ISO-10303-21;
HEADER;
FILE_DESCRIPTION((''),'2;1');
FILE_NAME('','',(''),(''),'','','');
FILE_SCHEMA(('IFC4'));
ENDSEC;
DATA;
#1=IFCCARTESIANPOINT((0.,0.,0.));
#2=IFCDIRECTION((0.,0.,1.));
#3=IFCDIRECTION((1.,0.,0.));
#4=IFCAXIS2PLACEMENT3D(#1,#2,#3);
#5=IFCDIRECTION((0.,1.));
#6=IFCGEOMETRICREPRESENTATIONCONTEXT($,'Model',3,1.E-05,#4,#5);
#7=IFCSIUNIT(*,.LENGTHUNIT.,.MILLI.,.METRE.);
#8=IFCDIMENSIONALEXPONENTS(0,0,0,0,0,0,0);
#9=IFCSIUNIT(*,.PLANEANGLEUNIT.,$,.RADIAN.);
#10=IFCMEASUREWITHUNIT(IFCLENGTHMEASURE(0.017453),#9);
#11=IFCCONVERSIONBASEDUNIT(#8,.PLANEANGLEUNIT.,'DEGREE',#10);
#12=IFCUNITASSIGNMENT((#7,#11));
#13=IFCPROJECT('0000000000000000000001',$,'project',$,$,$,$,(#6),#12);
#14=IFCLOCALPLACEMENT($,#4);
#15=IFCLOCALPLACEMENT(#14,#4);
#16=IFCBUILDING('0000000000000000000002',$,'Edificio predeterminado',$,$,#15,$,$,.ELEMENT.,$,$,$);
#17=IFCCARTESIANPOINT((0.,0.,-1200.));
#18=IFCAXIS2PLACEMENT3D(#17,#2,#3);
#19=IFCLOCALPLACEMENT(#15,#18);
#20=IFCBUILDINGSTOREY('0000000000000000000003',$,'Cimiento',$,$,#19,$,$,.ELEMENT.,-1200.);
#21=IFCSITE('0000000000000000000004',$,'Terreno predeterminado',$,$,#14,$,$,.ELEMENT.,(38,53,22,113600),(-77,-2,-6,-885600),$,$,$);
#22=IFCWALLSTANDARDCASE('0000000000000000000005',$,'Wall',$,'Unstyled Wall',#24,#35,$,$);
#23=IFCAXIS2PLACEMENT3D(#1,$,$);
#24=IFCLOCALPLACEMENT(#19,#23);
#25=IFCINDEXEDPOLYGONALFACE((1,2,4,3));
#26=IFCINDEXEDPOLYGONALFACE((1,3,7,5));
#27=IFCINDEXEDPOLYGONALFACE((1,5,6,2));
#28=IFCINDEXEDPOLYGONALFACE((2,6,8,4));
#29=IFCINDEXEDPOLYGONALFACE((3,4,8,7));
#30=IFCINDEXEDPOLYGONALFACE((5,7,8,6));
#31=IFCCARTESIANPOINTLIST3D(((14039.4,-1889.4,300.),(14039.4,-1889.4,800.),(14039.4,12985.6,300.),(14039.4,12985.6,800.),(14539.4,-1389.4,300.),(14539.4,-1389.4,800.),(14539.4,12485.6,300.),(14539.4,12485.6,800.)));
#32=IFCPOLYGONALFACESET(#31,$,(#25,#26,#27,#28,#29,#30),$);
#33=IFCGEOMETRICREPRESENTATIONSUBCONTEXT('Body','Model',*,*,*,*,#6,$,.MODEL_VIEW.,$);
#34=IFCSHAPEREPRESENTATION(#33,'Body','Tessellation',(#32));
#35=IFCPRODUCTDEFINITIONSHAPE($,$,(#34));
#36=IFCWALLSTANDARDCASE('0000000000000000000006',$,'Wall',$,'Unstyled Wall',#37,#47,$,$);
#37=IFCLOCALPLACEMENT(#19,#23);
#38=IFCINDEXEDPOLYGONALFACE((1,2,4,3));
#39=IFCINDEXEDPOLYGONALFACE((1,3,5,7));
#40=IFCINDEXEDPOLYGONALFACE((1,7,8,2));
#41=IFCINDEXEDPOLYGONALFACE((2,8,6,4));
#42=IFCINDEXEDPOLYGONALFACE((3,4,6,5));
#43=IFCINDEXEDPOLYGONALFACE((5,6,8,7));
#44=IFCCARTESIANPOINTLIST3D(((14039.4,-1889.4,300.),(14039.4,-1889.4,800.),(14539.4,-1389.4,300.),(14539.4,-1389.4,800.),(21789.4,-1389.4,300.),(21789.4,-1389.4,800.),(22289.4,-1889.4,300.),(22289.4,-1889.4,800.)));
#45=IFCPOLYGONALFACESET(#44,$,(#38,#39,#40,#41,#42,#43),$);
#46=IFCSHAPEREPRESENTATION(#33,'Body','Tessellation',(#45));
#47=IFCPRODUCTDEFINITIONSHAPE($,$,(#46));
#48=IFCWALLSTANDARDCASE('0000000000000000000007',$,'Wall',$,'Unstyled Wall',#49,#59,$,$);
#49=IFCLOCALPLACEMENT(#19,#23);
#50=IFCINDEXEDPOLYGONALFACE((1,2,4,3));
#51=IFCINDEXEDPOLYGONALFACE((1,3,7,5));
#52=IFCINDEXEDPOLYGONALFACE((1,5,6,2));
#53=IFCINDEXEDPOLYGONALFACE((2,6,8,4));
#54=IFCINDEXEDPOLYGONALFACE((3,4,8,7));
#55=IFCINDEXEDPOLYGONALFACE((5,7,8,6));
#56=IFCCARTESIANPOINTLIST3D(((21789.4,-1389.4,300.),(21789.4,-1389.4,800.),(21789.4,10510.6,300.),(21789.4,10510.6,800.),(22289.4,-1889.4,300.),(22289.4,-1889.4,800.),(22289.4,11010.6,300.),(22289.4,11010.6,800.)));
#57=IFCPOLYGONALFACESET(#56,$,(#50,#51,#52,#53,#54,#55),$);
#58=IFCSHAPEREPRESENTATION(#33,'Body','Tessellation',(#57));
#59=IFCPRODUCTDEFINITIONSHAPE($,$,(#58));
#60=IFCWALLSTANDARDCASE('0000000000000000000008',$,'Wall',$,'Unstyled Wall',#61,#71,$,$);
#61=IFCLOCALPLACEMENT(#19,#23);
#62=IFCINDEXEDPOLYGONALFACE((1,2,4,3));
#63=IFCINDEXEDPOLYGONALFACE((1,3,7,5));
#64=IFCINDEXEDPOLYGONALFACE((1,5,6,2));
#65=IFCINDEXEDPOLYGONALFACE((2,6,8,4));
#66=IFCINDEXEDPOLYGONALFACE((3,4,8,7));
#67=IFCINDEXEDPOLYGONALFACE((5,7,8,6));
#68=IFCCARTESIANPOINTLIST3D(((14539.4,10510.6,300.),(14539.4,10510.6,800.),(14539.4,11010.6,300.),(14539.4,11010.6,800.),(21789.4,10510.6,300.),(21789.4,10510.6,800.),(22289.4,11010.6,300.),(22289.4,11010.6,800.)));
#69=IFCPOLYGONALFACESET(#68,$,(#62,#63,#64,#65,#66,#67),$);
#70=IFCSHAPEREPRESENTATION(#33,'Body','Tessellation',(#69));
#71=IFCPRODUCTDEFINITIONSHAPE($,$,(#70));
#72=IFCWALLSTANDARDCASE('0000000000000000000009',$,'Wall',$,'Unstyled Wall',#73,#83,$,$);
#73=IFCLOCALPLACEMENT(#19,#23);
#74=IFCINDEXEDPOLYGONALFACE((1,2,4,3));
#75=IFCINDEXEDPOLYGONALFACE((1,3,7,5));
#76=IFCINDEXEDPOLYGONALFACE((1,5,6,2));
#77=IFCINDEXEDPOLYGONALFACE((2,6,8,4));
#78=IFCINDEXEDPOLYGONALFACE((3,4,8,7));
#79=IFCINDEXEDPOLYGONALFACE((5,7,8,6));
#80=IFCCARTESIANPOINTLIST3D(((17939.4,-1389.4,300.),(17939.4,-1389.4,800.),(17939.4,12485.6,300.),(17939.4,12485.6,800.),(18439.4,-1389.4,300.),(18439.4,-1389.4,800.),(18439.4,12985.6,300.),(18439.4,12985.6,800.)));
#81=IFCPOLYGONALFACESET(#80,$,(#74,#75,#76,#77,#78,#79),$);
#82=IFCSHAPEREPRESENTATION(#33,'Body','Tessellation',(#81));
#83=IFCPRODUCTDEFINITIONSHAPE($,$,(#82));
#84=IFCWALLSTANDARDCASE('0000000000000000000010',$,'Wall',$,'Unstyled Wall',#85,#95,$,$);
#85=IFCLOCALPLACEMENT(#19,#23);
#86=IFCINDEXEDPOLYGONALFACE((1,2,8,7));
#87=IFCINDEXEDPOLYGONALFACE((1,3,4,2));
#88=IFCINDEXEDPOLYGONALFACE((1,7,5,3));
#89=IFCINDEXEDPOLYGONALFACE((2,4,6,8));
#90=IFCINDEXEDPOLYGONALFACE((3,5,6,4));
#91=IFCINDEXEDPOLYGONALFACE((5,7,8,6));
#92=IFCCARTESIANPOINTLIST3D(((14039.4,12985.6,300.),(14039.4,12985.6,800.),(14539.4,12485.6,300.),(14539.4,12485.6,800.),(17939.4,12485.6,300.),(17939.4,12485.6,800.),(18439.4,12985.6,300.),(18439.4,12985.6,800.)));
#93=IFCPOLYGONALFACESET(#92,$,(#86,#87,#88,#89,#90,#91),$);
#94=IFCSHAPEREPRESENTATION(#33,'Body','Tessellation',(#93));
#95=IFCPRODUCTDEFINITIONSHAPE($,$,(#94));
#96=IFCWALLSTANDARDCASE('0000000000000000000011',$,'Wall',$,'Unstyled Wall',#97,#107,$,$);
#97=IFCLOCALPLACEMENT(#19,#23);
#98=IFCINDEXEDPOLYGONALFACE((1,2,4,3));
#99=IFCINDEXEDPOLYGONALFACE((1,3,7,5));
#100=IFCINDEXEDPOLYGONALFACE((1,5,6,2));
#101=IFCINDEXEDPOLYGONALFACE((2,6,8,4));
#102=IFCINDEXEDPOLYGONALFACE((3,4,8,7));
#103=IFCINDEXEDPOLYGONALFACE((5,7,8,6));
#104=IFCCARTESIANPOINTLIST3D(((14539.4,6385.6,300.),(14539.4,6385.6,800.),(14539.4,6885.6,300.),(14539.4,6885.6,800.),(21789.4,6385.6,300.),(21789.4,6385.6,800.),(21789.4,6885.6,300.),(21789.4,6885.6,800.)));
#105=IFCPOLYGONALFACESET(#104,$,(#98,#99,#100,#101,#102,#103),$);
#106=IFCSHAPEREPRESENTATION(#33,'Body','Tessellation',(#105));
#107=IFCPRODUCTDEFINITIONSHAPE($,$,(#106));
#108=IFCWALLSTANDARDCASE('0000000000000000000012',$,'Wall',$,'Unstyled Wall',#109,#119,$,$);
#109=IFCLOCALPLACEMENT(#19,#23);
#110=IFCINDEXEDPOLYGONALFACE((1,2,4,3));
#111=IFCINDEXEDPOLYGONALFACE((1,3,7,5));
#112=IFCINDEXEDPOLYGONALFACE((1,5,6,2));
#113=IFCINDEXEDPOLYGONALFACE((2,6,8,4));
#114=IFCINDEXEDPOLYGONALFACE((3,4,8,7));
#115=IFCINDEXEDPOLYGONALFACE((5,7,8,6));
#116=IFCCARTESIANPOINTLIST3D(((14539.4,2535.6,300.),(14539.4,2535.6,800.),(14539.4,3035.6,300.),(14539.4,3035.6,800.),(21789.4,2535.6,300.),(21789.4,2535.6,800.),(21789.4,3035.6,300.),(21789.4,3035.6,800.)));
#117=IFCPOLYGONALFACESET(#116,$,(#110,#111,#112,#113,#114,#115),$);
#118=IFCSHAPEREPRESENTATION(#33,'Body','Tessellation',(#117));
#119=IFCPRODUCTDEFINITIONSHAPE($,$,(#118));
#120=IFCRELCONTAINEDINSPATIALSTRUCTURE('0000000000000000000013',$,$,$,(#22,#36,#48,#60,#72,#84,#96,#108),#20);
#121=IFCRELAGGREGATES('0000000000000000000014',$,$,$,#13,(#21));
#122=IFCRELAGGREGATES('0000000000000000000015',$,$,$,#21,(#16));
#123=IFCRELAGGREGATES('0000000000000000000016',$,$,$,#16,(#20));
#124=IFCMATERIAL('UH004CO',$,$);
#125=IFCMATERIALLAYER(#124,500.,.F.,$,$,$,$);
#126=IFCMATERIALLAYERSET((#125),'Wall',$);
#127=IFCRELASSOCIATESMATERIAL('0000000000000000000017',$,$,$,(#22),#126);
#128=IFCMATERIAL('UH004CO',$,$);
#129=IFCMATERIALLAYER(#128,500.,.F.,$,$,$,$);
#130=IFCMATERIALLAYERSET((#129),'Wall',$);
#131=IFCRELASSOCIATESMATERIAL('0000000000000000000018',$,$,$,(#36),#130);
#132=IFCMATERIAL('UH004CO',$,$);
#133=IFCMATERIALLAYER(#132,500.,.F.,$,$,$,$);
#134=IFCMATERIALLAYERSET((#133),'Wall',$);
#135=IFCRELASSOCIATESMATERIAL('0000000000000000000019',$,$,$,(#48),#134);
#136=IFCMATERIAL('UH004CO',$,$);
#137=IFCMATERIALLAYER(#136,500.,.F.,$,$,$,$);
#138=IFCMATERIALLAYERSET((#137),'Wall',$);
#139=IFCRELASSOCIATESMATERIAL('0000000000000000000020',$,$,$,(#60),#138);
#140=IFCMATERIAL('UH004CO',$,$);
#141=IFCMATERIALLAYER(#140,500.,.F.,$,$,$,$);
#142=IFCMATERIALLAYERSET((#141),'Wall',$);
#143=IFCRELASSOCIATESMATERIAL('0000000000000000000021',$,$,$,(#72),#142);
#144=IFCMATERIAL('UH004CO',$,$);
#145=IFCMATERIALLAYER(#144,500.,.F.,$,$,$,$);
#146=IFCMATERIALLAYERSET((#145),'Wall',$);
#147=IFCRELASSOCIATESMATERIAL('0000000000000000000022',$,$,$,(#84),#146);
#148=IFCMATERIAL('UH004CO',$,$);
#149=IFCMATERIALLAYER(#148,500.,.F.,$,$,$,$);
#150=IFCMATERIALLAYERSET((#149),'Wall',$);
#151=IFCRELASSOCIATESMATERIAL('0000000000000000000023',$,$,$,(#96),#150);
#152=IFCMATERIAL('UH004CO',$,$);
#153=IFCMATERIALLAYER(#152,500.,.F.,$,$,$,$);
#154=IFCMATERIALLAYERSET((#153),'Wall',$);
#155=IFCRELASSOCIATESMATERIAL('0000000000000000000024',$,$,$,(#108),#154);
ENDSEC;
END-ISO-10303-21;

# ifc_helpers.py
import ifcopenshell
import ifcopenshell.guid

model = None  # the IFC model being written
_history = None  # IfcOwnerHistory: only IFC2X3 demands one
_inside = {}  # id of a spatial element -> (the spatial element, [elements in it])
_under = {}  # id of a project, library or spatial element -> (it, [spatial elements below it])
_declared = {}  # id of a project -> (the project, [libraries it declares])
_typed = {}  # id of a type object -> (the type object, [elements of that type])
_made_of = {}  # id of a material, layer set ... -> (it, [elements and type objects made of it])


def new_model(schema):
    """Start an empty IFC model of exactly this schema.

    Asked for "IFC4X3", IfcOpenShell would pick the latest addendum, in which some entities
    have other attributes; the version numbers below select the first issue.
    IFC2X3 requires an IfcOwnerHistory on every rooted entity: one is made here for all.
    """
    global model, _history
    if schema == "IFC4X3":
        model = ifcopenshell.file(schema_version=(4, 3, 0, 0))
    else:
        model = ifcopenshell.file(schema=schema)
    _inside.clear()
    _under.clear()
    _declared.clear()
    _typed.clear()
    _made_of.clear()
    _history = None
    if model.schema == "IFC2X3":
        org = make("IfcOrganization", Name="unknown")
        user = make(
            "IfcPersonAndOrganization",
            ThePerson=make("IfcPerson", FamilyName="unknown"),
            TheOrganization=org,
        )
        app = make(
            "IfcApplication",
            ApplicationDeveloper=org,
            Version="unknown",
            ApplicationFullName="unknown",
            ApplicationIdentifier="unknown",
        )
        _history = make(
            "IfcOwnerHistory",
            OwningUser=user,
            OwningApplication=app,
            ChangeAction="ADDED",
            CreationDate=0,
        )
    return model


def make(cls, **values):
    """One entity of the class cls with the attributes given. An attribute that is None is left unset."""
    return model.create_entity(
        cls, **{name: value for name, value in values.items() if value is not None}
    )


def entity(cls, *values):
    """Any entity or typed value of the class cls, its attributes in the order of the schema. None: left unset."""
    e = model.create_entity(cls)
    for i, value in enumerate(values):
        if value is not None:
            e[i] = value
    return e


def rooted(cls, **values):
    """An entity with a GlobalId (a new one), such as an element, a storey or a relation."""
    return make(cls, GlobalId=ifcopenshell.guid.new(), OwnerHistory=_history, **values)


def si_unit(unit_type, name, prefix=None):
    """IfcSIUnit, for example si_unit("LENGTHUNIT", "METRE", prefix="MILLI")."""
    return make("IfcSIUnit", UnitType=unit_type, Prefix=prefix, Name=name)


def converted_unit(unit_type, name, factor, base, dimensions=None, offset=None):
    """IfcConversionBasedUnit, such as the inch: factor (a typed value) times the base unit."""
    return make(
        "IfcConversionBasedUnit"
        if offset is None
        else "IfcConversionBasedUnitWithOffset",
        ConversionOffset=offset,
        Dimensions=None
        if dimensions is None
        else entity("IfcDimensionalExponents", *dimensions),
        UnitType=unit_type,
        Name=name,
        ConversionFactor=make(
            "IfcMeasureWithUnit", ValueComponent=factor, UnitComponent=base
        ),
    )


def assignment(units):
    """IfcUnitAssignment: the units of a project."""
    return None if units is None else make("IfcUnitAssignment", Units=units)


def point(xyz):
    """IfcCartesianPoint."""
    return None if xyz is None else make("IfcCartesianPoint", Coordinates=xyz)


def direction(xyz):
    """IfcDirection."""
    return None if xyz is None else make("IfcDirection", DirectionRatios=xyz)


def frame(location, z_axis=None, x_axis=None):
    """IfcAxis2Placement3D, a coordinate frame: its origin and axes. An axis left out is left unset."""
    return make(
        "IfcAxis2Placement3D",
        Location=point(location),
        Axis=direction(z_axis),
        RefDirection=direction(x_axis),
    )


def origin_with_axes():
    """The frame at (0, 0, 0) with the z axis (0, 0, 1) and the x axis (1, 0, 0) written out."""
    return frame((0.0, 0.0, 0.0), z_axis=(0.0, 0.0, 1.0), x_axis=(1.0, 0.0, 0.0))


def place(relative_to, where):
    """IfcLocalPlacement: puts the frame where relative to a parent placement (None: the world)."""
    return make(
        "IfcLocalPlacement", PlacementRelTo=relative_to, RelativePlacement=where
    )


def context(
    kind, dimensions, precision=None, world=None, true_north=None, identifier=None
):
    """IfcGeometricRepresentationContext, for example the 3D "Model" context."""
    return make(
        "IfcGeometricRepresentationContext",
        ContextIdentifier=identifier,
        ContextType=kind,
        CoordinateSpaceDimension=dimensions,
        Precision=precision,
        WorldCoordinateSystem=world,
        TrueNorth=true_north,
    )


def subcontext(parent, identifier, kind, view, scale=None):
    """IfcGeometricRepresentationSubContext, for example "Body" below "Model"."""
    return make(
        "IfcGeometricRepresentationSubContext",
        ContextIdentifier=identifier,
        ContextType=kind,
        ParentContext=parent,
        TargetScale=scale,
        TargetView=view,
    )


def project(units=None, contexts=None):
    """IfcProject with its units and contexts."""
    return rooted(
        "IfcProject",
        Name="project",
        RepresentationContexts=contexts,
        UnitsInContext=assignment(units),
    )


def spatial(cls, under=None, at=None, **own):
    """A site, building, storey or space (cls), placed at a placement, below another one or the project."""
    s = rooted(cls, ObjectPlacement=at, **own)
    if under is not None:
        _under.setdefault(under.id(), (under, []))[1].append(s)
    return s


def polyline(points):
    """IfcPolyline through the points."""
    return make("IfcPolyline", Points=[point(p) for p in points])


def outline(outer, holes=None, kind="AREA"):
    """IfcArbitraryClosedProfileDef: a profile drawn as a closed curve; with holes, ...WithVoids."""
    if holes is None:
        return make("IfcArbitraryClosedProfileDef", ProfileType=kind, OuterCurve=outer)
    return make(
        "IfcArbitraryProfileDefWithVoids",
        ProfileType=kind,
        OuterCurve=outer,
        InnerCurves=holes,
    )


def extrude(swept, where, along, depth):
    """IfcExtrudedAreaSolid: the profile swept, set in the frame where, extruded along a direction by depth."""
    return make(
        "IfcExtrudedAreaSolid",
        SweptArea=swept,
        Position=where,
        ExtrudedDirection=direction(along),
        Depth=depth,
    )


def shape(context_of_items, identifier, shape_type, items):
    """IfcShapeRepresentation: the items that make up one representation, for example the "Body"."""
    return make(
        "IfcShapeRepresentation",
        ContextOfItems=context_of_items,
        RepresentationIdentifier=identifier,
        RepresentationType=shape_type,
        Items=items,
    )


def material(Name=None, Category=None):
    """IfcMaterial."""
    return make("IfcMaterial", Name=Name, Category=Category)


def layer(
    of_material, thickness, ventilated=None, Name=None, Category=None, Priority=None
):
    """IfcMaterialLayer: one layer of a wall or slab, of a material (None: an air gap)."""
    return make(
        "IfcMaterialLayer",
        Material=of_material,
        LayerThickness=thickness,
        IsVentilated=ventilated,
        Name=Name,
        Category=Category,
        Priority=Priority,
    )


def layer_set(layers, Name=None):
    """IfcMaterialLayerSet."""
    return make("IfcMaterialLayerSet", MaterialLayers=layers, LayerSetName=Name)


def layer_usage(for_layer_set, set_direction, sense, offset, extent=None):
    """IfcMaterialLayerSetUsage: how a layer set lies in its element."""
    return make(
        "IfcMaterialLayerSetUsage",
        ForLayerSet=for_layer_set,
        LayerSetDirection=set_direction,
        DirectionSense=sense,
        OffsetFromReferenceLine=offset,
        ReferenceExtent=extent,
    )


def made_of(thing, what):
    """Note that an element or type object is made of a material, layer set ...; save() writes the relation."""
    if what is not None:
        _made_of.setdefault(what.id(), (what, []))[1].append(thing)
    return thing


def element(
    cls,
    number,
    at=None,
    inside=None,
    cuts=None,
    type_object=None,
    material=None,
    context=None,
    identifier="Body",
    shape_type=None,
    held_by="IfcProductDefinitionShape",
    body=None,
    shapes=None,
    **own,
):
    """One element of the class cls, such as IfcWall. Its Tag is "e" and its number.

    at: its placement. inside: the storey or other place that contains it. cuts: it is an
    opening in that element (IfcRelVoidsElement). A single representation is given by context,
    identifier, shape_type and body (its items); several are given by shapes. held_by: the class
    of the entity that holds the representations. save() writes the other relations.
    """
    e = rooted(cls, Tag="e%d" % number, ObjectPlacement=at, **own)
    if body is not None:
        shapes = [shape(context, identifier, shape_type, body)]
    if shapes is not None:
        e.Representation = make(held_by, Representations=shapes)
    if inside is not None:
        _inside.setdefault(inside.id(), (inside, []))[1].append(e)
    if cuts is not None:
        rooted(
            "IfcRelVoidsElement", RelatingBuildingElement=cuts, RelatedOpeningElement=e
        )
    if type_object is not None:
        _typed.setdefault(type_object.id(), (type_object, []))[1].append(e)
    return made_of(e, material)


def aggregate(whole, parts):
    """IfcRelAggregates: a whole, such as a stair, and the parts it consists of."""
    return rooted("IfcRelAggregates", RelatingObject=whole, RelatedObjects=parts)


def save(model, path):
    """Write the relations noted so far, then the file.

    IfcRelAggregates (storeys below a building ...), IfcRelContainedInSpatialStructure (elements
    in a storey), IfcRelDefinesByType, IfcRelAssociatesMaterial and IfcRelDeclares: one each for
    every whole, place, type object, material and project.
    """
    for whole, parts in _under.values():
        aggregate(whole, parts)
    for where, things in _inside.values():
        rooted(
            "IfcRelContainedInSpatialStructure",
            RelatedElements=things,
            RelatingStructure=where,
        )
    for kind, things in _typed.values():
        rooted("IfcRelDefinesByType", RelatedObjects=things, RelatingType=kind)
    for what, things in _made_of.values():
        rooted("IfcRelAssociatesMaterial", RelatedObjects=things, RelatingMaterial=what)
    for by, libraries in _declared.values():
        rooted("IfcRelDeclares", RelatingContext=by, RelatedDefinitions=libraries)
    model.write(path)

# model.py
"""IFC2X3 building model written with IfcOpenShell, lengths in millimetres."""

from ifc_helpers import new_model, entity, si_unit, converted_unit, direction, frame, origin_with_axes, place, context, subcontext, project, spatial, polyline, outline, extrude, material, layer, layer_set, layer_usage, element, save


model = new_model("IFC2X3")

# Units and contexts
model_context = context("Model", 3, precision=1e-05, world=origin_with_axes(), true_north=direction((0.0, 1.0)))
body_context = subcontext(model_context, "Body", "Model", "MODEL_VIEW")
ifc_project = project(units=[si_unit("LENGTHUNIT", "METRE", prefix="MILLI"), converted_unit("PLANEANGLEUNIT", "DEGREE", entity("IfcLengthMeasure", 0.017453), si_unit("PLANEANGLEUNIT", "RADIAN"), dimensions=[0, 0, 0, 0, 0, 0, 0])], contexts=[model_context])

# Site, building, storey
site_placement = place(None, origin_with_axes())
site = spatial("IfcSite", under=ifc_project, at=site_placement, Name="Terreno predeterminado", CompositionType="ELEMENT", RefLatitude=(38, 53, 22, 113600), RefLongitude=(-77, -2, -6, -885600))
building_placement = place(site_placement, origin_with_axes())
building = spatial("IfcBuilding", under=site, at=building_placement, Name="Edificio predeterminado", CompositionType="ELEMENT")
storey_placement = place(building_placement, frame((0.0, 0.0, -1200.0), z_axis=(0.0, 0.0, 1.0), x_axis=(1.0, 0.0, 0.0)))
storey = spatial("IfcBuildingStorey", under=building, at=storey_placement, Name="Cimiento", CompositionType="ELEMENT", Elevation=-1200.0)

# Walls
ifc_material_1 = material(Name="UH004CO")
ifc_layer_1 = layer(ifc_material_1, 500.0, ventilated=False)
ifc_layer_set_1 = layer_set([ifc_layer_1], Name="Wall")
ifc_layer_usage_1 = layer_usage(ifc_layer_set_1, "AXIS2", "POSITIVE", -250.0)
wall_1_placement = place(storey_placement, frame((14289.4, 12735.6, 300.0), z_axis=(0.0, 0.0, 1.0), x_axis=(0.0, -1.0, 0.0)))
element("IfcWallStandardCase", 1, at=wall_1_placement, inside=storey, material=ifc_layer_usage_1, Name="Wall", ObjectType="Unstyled Wall", context=body_context, shape_type="SweptSolid", body=[
    extrude(outline(polyline([(250.0, 250.0), (-250.0, -250.0), (14625.0, -250.0), (14125.0, 250.0), (250.0, 250.0)])), origin_with_axes(), (0.0, 0.0, 1.0), 500.0),
])
ifc_material_2 = material(Name="UH004CO")
ifc_layer_2 = layer(ifc_material_2, 500.0, ventilated=False)
ifc_layer_set_2 = layer_set([ifc_layer_2], Name="Wall")
ifc_layer_usage_2 = layer_usage(ifc_layer_set_2, "AXIS2", "POSITIVE", -250.0)
wall_2_placement = place(storey_placement, frame((14289.4, -1639.4, 300.0), z_axis=(0.0, 0.0, 1.0), x_axis=(1.0, 0.0, 0.0)))
element("IfcWallStandardCase", 2, at=wall_2_placement, inside=storey, material=ifc_layer_usage_2, Name="Wall", ObjectType="Unstyled Wall", context=body_context, shape_type="SweptSolid", body=[
    extrude(outline(polyline([(-250.0, -250.0), (250.0, 250.0), (7500.0, 250.0), (8000.0, -250.0), (-250.0, -250.0)])), origin_with_axes(), (0.0, 0.0, 1.0), 500.0),
])
ifc_material_3 = material(Name="UH004CO")
ifc_layer_3 = layer(ifc_material_3, 500.0, ventilated=False)
ifc_layer_set_3 = layer_set([ifc_layer_3], Name="Wall")
ifc_layer_usage_3 = layer_usage(ifc_layer_set_3, "AXIS2", "POSITIVE", -250.0)
wall_3_placement = place(storey_placement, frame((22039.4, -1639.4, 300.0), z_axis=(0.0, 0.0, 1.0), x_axis=(0.0, 1.0, 0.0)))
element("IfcWallStandardCase", 3, at=wall_3_placement, inside=storey, material=ifc_layer_usage_3, Name="Wall", ObjectType="Unstyled Wall", context=body_context, shape_type="SweptSolid", body=[
    extrude(outline(polyline([(-250.0, -250.0), (250.0, 250.0), (12150.0, 250.0), (12650.0, -250.0), (-250.0, -250.0)])), origin_with_axes(), (0.0, 0.0, 1.0), 500.0),
])
ifc_material_4 = material(Name="UH004CO")
ifc_layer_4 = layer(ifc_material_4, 500.0, ventilated=False)
ifc_layer_set_4 = layer_set([ifc_layer_4], Name="Wall")
ifc_layer_usage_4 = layer_usage(ifc_layer_set_4, "AXIS2", "POSITIVE", -250.0)
wall_4_placement = place(storey_placement, frame((22039.4, 10760.6, 300.0), z_axis=(0.0, 0.0, 1.0), x_axis=(-1.0, 0.0, 0.0)))
element("IfcWallStandardCase", 4, at=wall_4_placement, inside=storey, material=ifc_layer_usage_4, Name="Wall", ObjectType="Unstyled Wall", context=body_context, shape_type="SweptSolid", body=[
    extrude(outline(polyline([(-250.0, -250.0), (250.0, 250.0), (7500.0, 250.0), (7500.0, -250.0), (-250.0, -250.0)])), origin_with_axes(), (0.0, 0.0, 1.0), 500.0),
])
ifc_material_5 = material(Name="UH004CO")
ifc_layer_5 = layer(ifc_material_5, 500.0, ventilated=False)
ifc_layer_set_5 = layer_set([ifc_layer_5], Name="Wall")
ifc_layer_usage_5 = layer_usage(ifc_layer_set_5, "AXIS2", "POSITIVE", -250.0)
wall_5_placement = place(storey_placement, frame((18189.4, -1639.4, 300.0), z_axis=(0.0, 0.0, 1.0), x_axis=(0.0, 1.0, 0.0)))
element("IfcWallStandardCase", 5, at=wall_5_placement, inside=storey, material=ifc_layer_usage_5, Name="Wall", ObjectType="Unstyled Wall", context=body_context, shape_type="SweptSolid", body=[
    extrude(outline(polyline([(250.0, 250.0), (250.0, -250.0), (14625.0, -250.0), (14125.0, 250.0), (250.0, 250.0)])), origin_with_axes(), (0.0, 0.0, 1.0), 500.0),
])
ifc_material_6 = material(Name="UH004CO")
ifc_layer_6 = layer(ifc_material_6, 500.0, ventilated=False)
ifc_layer_set_6 = layer_set([ifc_layer_6], Name="Wall")
ifc_layer_usage_6 = layer_usage(ifc_layer_set_6, "AXIS2", "POSITIVE", -250.0)
wall_6_placement = place(storey_placement, frame((18189.4, 12735.6, 300.0), z_axis=(0.0, 0.0, 1.0), x_axis=(-1.0, 0.0, 0.0)))
element("IfcWallStandardCase", 6, at=wall_6_placement, inside=storey, material=ifc_layer_usage_6, Name="Wall", ObjectType="Unstyled Wall", context=body_context, shape_type="SweptSolid", body=[
    extrude(outline(polyline([(-250.0, -250.0), (250.0, 250.0), (3650.0, 250.0), (4150.0, -250.0), (-250.0, -250.0)])), origin_with_axes(), (0.0, 0.0, 1.0), 500.0),
])
ifc_material_7 = material(Name="UH004CO")
ifc_layer_7 = layer(ifc_material_7, 500.0, ventilated=False)
ifc_layer_set_7 = layer_set([ifc_layer_7], Name="Wall")
ifc_layer_usage_7 = layer_usage(ifc_layer_set_7, "AXIS2", "POSITIVE", -250.0)
wall_7_placement = place(storey_placement, frame((14289.4, 6635.6, 300.0), z_axis=(0.0, 0.0, 1.0), x_axis=(1.0, 0.0, 0.0)))
element("IfcWallStandardCase", 7, at=wall_7_placement, inside=storey, material=ifc_layer_usage_7, Name="Wall", ObjectType="Unstyled Wall", context=body_context, shape_type="SweptSolid", body=[
    extrude(outline(polyline([(250.0, -250.0), (250.0, 250.0), (7500.0, 250.0), (7500.0, -250.0), (250.0, -250.0)])), origin_with_axes(), (0.0, 0.0, 1.0), 500.0),
])
ifc_material_8 = material(Name="UH004CO")
ifc_layer_8 = layer(ifc_material_8, 500.0, ventilated=False)
ifc_layer_set_8 = layer_set([ifc_layer_8], Name="Wall")
ifc_layer_usage_8 = layer_usage(ifc_layer_set_8, "AXIS2", "POSITIVE", -250.0)
wall_8_placement = place(storey_placement, frame((14289.4, 2785.6, 300.0), z_axis=(0.0, 0.0, 1.0), x_axis=(1.0, 0.0, 0.0)))
element("IfcWallStandardCase", 8, at=wall_8_placement, inside=storey, material=ifc_layer_usage_8, Name="Wall", ObjectType="Unstyled Wall", context=body_context, shape_type="SweptSolid", body=[
    extrude(outline(polyline([(250.0, -250.0), (250.0, 250.0), (7500.0, 250.0), (7500.0, -250.0), (250.0, -250.0)])), origin_with_axes(), (0.0, 0.0, 1.0), 500.0),
])

save(model, "model.ifc")
